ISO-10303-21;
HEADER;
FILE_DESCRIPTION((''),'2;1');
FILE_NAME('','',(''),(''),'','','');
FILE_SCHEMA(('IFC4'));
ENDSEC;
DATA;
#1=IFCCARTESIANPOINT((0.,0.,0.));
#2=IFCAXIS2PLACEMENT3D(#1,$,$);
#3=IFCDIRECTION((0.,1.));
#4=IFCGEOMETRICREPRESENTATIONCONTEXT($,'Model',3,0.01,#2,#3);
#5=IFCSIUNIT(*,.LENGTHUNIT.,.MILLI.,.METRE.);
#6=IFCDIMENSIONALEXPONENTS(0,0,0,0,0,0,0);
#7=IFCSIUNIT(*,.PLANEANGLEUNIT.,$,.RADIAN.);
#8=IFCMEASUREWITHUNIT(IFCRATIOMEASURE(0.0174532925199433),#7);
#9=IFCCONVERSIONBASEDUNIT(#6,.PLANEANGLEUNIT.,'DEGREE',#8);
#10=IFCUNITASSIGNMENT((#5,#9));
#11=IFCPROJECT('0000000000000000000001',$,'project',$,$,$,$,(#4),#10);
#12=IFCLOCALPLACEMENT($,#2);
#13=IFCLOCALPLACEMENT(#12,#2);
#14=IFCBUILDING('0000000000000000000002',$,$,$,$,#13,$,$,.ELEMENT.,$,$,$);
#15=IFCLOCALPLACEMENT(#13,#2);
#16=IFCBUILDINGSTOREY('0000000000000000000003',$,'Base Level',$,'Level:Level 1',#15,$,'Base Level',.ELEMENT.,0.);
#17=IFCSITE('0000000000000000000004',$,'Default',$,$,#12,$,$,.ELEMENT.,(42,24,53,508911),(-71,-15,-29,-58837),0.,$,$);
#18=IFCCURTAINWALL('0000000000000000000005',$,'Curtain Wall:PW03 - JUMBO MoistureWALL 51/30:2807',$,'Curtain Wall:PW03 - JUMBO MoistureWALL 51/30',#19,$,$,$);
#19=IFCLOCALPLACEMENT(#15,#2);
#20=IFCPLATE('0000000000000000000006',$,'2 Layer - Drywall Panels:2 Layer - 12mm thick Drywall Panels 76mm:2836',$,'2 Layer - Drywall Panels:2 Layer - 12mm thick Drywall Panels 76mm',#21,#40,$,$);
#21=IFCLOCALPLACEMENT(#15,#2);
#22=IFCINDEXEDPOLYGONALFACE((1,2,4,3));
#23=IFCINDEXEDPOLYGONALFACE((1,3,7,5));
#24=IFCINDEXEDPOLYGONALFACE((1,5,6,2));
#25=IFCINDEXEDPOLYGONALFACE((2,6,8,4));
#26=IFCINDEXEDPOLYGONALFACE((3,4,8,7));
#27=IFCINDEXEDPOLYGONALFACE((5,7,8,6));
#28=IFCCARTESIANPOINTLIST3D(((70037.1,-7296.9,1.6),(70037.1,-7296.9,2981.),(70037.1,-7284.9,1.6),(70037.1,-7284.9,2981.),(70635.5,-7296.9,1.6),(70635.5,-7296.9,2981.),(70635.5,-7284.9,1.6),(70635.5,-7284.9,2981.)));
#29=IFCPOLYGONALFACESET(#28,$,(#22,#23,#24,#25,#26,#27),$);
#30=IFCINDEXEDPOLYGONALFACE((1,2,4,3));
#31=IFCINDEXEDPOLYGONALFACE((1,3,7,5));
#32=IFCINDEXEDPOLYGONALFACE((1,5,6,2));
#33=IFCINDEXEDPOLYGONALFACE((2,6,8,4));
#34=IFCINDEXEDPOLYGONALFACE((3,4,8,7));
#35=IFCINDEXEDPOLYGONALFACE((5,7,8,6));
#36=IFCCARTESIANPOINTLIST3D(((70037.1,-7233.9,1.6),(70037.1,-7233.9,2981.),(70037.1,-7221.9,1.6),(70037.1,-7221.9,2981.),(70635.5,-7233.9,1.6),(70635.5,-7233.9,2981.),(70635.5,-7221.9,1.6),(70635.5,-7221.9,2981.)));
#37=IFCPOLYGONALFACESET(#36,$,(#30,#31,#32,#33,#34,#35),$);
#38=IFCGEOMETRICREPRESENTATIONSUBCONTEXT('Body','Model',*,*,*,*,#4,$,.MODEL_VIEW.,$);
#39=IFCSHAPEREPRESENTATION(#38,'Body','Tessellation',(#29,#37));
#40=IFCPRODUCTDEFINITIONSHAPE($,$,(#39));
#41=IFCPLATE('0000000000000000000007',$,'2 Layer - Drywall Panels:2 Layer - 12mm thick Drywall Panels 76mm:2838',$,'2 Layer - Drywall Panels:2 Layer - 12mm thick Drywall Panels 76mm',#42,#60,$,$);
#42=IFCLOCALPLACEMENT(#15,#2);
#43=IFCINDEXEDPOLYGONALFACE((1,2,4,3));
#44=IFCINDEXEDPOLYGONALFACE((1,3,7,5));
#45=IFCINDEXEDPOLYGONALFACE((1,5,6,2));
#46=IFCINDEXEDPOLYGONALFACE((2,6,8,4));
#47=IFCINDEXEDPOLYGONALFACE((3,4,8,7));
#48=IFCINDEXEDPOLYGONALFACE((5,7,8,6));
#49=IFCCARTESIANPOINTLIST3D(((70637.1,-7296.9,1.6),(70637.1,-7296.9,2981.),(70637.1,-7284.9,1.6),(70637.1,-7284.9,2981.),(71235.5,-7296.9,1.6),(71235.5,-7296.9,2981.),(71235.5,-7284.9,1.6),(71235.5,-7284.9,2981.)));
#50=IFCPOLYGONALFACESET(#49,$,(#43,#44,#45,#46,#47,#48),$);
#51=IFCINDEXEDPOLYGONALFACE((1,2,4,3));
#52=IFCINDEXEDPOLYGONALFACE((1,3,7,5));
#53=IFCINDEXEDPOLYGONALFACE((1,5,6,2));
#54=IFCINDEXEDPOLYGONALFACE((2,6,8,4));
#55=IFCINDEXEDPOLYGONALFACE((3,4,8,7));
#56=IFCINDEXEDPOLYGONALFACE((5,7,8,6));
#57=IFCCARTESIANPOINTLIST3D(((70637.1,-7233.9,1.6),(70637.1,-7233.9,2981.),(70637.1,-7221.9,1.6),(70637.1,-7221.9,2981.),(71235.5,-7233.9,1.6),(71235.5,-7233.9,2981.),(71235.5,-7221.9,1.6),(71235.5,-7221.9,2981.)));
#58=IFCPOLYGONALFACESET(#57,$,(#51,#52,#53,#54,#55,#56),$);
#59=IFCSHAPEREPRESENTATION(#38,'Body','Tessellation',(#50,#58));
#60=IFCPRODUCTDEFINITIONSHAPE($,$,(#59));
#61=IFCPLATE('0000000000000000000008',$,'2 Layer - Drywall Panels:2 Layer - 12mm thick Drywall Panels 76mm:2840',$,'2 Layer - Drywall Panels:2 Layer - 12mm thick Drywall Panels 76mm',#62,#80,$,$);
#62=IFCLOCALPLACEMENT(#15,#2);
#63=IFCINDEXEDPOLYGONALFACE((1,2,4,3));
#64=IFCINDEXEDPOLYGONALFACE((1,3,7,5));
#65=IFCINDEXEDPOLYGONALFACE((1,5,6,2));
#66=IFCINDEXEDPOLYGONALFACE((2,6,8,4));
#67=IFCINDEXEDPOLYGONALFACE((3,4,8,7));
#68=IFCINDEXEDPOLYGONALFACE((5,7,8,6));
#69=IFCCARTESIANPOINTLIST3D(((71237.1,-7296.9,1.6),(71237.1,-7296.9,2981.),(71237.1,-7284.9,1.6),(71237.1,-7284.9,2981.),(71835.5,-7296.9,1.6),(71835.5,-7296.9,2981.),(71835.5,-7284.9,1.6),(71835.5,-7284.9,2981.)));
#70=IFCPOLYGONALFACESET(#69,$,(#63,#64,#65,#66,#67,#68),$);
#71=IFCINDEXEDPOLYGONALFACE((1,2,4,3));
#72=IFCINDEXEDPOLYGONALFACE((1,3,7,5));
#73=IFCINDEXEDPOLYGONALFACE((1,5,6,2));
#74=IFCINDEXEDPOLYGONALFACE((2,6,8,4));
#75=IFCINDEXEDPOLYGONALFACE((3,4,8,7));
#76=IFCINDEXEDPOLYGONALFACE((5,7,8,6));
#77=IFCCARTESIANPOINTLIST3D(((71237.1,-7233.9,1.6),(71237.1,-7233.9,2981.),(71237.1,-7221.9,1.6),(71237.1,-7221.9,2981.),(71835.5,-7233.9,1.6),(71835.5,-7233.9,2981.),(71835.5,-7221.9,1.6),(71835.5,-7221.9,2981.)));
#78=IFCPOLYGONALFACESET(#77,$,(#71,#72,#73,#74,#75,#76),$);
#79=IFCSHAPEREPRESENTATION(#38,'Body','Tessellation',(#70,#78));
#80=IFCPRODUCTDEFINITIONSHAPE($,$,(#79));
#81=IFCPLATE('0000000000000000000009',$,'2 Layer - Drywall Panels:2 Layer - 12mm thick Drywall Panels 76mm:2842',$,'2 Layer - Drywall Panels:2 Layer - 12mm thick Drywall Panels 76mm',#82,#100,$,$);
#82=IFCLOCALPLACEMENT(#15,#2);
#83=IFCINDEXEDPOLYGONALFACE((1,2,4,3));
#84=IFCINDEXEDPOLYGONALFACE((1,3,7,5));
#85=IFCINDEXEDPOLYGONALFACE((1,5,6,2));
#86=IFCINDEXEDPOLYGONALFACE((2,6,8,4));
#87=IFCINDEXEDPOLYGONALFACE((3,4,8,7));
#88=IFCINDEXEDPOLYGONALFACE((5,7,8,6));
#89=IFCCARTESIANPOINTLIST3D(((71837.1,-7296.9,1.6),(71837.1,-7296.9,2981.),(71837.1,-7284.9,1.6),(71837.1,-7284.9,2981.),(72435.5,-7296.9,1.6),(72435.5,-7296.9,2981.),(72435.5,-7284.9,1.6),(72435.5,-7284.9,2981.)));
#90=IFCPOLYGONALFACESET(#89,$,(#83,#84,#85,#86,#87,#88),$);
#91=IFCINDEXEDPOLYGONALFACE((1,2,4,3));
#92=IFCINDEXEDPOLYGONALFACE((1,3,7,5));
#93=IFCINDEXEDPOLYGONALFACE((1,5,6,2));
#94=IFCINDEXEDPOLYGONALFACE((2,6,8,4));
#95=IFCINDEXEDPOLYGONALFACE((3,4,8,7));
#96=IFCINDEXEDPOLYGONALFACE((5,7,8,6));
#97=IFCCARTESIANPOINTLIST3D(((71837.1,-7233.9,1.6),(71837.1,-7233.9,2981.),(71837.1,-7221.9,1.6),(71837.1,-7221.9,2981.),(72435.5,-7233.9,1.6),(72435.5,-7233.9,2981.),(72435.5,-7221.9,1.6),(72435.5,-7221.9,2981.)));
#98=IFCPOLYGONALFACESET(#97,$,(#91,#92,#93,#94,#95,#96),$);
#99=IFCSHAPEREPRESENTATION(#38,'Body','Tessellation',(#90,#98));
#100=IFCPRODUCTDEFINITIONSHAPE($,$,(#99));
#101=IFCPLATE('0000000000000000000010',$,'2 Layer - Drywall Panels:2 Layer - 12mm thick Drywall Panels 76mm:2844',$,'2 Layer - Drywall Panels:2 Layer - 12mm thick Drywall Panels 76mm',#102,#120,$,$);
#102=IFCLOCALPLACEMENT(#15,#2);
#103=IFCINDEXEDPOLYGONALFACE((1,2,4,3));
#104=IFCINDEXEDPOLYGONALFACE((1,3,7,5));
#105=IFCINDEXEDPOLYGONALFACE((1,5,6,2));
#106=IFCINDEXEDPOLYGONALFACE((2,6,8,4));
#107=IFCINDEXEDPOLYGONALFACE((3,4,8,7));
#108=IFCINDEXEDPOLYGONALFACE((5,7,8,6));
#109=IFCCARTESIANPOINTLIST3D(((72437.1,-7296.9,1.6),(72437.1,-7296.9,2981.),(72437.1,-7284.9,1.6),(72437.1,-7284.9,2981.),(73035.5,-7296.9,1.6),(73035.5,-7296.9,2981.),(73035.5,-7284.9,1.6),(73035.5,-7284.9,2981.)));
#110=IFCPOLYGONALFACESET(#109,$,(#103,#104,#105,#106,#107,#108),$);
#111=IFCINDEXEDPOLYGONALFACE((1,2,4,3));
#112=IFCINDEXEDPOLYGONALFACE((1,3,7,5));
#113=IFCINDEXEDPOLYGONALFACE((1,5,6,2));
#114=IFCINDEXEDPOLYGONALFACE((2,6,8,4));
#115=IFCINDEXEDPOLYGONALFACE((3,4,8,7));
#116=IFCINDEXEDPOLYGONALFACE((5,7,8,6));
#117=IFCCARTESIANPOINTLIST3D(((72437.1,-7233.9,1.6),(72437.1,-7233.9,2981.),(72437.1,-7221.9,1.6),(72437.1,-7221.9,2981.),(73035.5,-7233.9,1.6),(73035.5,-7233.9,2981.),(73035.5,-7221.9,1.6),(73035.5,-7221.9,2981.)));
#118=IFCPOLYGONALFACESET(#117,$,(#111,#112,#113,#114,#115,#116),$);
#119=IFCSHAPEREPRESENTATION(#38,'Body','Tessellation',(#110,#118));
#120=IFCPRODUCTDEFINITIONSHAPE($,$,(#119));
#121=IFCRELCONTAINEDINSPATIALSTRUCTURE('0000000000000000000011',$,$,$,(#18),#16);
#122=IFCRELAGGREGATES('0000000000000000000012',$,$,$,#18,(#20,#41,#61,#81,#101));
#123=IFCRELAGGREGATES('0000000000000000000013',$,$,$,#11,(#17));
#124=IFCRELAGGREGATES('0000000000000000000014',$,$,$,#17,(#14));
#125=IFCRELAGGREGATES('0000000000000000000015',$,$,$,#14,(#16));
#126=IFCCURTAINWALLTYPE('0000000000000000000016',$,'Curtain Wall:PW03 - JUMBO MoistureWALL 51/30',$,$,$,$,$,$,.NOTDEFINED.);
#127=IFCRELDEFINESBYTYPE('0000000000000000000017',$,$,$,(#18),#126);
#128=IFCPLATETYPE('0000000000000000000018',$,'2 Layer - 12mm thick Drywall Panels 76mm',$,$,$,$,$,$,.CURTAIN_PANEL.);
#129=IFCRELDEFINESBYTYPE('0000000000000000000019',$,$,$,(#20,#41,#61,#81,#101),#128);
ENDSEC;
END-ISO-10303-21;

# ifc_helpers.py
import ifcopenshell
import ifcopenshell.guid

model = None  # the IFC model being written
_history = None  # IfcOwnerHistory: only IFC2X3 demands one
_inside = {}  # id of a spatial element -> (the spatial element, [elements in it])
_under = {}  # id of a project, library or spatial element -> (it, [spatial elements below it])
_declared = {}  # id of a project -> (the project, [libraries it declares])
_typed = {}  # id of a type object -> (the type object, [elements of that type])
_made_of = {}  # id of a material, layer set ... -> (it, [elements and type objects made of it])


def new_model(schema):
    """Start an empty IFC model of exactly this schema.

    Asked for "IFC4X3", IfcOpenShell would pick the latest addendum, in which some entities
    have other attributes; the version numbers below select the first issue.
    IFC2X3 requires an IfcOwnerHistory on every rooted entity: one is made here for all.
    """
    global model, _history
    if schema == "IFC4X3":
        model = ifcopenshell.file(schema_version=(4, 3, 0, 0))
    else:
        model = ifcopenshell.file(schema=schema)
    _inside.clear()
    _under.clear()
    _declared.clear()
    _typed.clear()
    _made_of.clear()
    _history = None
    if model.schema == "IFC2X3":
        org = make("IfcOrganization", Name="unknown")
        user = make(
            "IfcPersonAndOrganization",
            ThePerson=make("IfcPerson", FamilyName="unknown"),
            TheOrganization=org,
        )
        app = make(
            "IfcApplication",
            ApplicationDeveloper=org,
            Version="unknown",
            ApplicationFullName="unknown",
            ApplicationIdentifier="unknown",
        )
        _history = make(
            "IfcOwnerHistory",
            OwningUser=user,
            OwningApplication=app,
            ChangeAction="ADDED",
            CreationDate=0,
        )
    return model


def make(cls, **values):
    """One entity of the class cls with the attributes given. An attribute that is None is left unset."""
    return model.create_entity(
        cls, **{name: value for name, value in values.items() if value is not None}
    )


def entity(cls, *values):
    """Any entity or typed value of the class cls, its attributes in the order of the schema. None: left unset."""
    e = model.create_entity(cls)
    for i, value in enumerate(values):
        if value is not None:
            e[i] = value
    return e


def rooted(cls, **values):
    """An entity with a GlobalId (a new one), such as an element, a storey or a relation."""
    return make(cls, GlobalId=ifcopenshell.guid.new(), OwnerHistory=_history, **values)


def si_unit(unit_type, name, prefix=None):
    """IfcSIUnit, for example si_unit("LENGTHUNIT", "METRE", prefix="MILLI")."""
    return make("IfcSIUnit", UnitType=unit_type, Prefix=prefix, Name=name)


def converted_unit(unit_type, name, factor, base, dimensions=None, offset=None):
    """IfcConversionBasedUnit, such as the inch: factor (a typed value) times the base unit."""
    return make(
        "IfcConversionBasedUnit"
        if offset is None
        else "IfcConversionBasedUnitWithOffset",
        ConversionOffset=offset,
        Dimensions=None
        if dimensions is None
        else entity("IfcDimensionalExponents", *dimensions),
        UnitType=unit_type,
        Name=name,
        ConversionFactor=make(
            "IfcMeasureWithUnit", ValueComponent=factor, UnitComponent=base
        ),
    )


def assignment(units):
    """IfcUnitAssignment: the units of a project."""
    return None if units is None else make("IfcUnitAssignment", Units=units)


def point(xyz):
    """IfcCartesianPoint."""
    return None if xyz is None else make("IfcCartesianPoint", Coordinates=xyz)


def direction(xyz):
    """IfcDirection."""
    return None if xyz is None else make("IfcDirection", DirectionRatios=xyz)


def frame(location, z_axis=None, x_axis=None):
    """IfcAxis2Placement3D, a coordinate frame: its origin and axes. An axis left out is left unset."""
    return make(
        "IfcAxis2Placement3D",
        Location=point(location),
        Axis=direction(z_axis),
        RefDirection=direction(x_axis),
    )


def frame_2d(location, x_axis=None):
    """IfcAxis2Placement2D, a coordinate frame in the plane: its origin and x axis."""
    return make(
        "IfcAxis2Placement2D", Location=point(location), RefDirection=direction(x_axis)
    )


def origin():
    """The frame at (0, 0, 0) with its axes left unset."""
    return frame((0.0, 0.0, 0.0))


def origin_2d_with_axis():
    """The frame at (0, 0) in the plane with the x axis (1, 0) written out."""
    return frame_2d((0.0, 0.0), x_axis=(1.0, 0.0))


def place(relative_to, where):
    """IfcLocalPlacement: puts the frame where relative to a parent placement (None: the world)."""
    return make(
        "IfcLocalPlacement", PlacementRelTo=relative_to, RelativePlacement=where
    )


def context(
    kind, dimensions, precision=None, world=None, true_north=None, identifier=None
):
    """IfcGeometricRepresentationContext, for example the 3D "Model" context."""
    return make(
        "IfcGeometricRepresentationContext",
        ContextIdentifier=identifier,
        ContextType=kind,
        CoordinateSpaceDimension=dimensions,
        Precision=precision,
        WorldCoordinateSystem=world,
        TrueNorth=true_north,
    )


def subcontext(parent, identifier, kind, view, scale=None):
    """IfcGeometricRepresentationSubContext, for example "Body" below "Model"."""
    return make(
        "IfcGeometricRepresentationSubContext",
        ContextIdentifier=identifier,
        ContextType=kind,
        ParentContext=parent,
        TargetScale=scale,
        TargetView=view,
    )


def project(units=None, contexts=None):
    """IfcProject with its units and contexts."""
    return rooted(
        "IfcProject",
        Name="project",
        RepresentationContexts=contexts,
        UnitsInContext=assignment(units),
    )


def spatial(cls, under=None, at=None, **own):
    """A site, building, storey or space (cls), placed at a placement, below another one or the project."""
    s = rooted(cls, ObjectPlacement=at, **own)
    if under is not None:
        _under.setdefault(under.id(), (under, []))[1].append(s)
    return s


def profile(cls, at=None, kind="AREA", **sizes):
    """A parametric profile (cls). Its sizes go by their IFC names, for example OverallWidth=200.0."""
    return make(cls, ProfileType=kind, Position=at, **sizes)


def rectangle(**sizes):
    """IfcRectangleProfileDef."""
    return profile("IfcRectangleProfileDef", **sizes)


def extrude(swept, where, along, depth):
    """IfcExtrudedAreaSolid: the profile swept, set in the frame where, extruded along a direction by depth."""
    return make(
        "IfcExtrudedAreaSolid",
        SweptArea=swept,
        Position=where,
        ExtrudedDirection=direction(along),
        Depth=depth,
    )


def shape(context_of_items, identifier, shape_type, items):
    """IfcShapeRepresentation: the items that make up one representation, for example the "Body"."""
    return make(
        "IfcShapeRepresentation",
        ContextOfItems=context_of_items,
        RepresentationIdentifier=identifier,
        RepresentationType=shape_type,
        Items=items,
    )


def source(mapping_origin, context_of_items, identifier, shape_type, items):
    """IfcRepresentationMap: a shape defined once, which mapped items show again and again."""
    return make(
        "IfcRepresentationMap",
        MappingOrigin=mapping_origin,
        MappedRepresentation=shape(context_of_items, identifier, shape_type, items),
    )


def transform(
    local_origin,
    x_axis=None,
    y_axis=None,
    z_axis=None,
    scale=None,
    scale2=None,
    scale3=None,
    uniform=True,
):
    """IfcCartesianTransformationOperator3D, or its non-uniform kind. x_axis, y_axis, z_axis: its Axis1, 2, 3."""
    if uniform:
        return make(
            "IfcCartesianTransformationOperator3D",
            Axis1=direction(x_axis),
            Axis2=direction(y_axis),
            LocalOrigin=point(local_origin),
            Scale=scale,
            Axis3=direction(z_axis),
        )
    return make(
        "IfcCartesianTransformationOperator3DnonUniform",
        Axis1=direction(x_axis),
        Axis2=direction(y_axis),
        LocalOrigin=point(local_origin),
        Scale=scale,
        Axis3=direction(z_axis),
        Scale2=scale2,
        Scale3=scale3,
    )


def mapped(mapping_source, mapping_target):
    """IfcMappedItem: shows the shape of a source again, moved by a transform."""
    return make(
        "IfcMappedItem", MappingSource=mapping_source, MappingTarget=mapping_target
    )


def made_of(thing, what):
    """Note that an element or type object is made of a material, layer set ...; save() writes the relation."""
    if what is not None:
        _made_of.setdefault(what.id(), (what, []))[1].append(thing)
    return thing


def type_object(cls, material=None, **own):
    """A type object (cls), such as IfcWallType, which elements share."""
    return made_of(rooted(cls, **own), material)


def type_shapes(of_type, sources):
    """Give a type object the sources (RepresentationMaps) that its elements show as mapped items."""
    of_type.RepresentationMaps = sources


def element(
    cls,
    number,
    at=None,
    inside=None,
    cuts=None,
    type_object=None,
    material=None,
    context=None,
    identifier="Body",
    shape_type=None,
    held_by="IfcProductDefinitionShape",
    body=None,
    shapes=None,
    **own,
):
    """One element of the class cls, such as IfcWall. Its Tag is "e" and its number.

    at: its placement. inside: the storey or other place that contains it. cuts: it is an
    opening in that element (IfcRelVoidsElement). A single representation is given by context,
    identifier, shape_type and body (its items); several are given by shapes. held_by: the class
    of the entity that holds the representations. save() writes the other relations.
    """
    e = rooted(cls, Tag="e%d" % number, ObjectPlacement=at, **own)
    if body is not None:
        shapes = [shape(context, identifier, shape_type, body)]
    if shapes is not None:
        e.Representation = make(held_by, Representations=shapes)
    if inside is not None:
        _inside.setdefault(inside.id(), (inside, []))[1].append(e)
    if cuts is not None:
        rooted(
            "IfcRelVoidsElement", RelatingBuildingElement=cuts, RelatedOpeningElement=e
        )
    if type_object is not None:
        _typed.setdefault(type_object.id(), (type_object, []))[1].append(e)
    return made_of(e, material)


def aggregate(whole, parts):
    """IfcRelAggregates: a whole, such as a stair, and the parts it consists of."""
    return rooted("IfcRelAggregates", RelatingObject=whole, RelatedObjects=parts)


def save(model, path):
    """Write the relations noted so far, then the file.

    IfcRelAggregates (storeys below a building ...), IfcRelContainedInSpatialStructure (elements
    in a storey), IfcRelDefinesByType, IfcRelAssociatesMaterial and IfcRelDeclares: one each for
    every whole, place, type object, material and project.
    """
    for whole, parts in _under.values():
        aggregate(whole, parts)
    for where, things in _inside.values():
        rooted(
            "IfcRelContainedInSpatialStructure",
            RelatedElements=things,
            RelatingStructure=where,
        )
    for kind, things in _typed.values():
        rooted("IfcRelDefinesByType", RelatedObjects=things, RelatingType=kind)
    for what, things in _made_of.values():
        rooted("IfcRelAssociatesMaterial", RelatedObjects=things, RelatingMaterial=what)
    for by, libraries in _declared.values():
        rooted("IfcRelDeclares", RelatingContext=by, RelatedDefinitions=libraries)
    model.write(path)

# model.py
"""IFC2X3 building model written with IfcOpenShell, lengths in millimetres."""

from ifc_helpers import new_model, entity, si_unit, converted_unit, direction, frame, frame_2d, origin, origin_2d_with_axis, place, context, subcontext, project, spatial, rectangle, extrude, source, transform, mapped, type_object, type_shapes, element, aggregate, save


model = new_model("IFC2X3")

# Units and contexts
model_context = context("Model", 3, precision=0.01, world=origin(), true_north=direction((0.0, 1.0)))
body_context = subcontext(model_context, "Body", "Model", "MODEL_VIEW")
ifc_project = project(units=[si_unit("LENGTHUNIT", "METRE", prefix="MILLI"), converted_unit("PLANEANGLEUNIT", "DEGREE", entity("IfcRatioMeasure", 0.0174532925199433), si_unit("PLANEANGLEUNIT", "RADIAN"), dimensions=[0, 0, 0, 0, 0, 0, 0])], contexts=[model_context])

# Site, building, storey
site_placement = place(None, origin())
site = spatial("IfcSite", under=ifc_project, at=site_placement, Name="Default", CompositionType="ELEMENT", RefLatitude=(42, 24, 53, 508911), RefLongitude=(-71, -15, -29, -58837), RefElevation=0.0)
building_placement = place(site_placement, origin())
building = spatial("IfcBuilding", under=site, at=building_placement, CompositionType="ELEMENT")
storey_placement = place(building_placement, origin())
storey = spatial("IfcBuildingStorey", under=building, at=storey_placement, Name="Base Level", ObjectType="Level:Level 1", LongName="Base Level", CompositionType="ELEMENT", Elevation=0.0)

# Curtain wall, plates
curtain_wall_type = type_object("IfcCurtainWallType", Name="Curtain Wall:PW03 - JUMBO MoistureWALL 51/30", PredefinedType="NOTDEFINED")
curtain_wall_placement = place(building_placement, origin())
curtain_wall = element("IfcCurtainWall", 1, at=curtain_wall_placement, inside=storey, type_object=curtain_wall_type, Name="Curtain Wall:PW03 - JUMBO MoistureWALL 51/30:2807", ObjectType="Curtain Wall:PW03 - JUMBO MoistureWALL 51/30")
plate_type = type_object("IfcPlateType", Name="2 Layer - 12mm thick Drywall Panels 76mm", PredefinedType="CURTAIN_PANEL")
shared_shape_1 = source(origin(), body_context, "Body", "SweptSolid", [
    extrude(rectangle(XDim=598.4, YDim=12.0, at=origin_2d_with_axis()), frame((0.0, -31.5, 0.0), z_axis=(0.0, 0.0, 1.0), x_axis=(-1.0, 0.0, 0.0)), (0.0, 0.0, 1.0), 2979.4),
    extrude(rectangle(XDim=12.0, YDim=598.4, at=frame_2d((0.0, 0.0), x_axis=(1.0, 0.0))), frame((0.0, 31.5, 0.0), z_axis=(0.0, 0.0, 1.0), x_axis=(0.0, 1.0, 0.0)), (0.0, 0.0, 1.0), 2979.4),
])
type_shapes(plate_type, [shared_shape_1])
plate_1_placement = place(curtain_wall_placement, frame((70336.3, -7259.4, 1.6)))
plate_1 = element("IfcPlate", 2, at=plate_1_placement, type_object=plate_type, Name="2 Layer - Drywall Panels:2 Layer - 12mm thick Drywall Panels 76mm:2836", ObjectType="2 Layer - Drywall Panels:2 Layer - 12mm thick Drywall Panels 76mm", context=body_context, shape_type="MappedRepresentation", body=[
    mapped(shared_shape_1, transform((0.0, 0.0, 0.0), scale=1.0)),
])
plate_2_placement = place(curtain_wall_placement, frame((70936.3, -7259.4, 1.6)))
plate_2 = element("IfcPlate", 3, at=plate_2_placement, type_object=plate_type, Name="2 Layer - Drywall Panels:2 Layer - 12mm thick Drywall Panels 76mm:2838", ObjectType="2 Layer - Drywall Panels:2 Layer - 12mm thick Drywall Panels 76mm", context=body_context, shape_type="MappedRepresentation", body=[
    mapped(shared_shape_1, transform((0.0, 0.0, 0.0), scale=1.0)),
])
plate_3_placement = place(curtain_wall_placement, frame((71536.3, -7259.4, 1.6)))
plate_3 = element("IfcPlate", 4, at=plate_3_placement, type_object=plate_type, Name="2 Layer - Drywall Panels:2 Layer - 12mm thick Drywall Panels 76mm:2840", ObjectType="2 Layer - Drywall Panels:2 Layer - 12mm thick Drywall Panels 76mm", context=body_context, shape_type="MappedRepresentation", body=[
    mapped(shared_shape_1, transform((0.0, 0.0, 0.0), scale=1.0)),
])
plate_4_placement = place(curtain_wall_placement, frame((72136.3, -7259.4, 1.6)))
plate_4 = element("IfcPlate", 5, at=plate_4_placement, type_object=plate_type, Name="2 Layer - Drywall Panels:2 Layer - 12mm thick Drywall Panels 76mm:2842", ObjectType="2 Layer - Drywall Panels:2 Layer - 12mm thick Drywall Panels 76mm", context=body_context, shape_type="MappedRepresentation", body=[
    mapped(shared_shape_1, transform((0.0, 0.0, 0.0), scale=1.0)),
])
plate_5_placement = place(curtain_wall_placement, frame((72736.3, -7259.4, 1.6)))
plate_5 = element("IfcPlate", 6, at=plate_5_placement, type_object=plate_type, Name="2 Layer - Drywall Panels:2 Layer - 12mm thick Drywall Panels 76mm:2844", ObjectType="2 Layer - Drywall Panels:2 Layer - 12mm thick Drywall Panels 76mm", context=body_context, shape_type="MappedRepresentation", body=[
    mapped(shared_shape_1, transform((0.0, 0.0, 0.0), scale=1.0)),
])
aggregate(curtain_wall, [plate_1, plate_2, plate_3, plate_4, plate_5])

save(model, "model.ifc")
